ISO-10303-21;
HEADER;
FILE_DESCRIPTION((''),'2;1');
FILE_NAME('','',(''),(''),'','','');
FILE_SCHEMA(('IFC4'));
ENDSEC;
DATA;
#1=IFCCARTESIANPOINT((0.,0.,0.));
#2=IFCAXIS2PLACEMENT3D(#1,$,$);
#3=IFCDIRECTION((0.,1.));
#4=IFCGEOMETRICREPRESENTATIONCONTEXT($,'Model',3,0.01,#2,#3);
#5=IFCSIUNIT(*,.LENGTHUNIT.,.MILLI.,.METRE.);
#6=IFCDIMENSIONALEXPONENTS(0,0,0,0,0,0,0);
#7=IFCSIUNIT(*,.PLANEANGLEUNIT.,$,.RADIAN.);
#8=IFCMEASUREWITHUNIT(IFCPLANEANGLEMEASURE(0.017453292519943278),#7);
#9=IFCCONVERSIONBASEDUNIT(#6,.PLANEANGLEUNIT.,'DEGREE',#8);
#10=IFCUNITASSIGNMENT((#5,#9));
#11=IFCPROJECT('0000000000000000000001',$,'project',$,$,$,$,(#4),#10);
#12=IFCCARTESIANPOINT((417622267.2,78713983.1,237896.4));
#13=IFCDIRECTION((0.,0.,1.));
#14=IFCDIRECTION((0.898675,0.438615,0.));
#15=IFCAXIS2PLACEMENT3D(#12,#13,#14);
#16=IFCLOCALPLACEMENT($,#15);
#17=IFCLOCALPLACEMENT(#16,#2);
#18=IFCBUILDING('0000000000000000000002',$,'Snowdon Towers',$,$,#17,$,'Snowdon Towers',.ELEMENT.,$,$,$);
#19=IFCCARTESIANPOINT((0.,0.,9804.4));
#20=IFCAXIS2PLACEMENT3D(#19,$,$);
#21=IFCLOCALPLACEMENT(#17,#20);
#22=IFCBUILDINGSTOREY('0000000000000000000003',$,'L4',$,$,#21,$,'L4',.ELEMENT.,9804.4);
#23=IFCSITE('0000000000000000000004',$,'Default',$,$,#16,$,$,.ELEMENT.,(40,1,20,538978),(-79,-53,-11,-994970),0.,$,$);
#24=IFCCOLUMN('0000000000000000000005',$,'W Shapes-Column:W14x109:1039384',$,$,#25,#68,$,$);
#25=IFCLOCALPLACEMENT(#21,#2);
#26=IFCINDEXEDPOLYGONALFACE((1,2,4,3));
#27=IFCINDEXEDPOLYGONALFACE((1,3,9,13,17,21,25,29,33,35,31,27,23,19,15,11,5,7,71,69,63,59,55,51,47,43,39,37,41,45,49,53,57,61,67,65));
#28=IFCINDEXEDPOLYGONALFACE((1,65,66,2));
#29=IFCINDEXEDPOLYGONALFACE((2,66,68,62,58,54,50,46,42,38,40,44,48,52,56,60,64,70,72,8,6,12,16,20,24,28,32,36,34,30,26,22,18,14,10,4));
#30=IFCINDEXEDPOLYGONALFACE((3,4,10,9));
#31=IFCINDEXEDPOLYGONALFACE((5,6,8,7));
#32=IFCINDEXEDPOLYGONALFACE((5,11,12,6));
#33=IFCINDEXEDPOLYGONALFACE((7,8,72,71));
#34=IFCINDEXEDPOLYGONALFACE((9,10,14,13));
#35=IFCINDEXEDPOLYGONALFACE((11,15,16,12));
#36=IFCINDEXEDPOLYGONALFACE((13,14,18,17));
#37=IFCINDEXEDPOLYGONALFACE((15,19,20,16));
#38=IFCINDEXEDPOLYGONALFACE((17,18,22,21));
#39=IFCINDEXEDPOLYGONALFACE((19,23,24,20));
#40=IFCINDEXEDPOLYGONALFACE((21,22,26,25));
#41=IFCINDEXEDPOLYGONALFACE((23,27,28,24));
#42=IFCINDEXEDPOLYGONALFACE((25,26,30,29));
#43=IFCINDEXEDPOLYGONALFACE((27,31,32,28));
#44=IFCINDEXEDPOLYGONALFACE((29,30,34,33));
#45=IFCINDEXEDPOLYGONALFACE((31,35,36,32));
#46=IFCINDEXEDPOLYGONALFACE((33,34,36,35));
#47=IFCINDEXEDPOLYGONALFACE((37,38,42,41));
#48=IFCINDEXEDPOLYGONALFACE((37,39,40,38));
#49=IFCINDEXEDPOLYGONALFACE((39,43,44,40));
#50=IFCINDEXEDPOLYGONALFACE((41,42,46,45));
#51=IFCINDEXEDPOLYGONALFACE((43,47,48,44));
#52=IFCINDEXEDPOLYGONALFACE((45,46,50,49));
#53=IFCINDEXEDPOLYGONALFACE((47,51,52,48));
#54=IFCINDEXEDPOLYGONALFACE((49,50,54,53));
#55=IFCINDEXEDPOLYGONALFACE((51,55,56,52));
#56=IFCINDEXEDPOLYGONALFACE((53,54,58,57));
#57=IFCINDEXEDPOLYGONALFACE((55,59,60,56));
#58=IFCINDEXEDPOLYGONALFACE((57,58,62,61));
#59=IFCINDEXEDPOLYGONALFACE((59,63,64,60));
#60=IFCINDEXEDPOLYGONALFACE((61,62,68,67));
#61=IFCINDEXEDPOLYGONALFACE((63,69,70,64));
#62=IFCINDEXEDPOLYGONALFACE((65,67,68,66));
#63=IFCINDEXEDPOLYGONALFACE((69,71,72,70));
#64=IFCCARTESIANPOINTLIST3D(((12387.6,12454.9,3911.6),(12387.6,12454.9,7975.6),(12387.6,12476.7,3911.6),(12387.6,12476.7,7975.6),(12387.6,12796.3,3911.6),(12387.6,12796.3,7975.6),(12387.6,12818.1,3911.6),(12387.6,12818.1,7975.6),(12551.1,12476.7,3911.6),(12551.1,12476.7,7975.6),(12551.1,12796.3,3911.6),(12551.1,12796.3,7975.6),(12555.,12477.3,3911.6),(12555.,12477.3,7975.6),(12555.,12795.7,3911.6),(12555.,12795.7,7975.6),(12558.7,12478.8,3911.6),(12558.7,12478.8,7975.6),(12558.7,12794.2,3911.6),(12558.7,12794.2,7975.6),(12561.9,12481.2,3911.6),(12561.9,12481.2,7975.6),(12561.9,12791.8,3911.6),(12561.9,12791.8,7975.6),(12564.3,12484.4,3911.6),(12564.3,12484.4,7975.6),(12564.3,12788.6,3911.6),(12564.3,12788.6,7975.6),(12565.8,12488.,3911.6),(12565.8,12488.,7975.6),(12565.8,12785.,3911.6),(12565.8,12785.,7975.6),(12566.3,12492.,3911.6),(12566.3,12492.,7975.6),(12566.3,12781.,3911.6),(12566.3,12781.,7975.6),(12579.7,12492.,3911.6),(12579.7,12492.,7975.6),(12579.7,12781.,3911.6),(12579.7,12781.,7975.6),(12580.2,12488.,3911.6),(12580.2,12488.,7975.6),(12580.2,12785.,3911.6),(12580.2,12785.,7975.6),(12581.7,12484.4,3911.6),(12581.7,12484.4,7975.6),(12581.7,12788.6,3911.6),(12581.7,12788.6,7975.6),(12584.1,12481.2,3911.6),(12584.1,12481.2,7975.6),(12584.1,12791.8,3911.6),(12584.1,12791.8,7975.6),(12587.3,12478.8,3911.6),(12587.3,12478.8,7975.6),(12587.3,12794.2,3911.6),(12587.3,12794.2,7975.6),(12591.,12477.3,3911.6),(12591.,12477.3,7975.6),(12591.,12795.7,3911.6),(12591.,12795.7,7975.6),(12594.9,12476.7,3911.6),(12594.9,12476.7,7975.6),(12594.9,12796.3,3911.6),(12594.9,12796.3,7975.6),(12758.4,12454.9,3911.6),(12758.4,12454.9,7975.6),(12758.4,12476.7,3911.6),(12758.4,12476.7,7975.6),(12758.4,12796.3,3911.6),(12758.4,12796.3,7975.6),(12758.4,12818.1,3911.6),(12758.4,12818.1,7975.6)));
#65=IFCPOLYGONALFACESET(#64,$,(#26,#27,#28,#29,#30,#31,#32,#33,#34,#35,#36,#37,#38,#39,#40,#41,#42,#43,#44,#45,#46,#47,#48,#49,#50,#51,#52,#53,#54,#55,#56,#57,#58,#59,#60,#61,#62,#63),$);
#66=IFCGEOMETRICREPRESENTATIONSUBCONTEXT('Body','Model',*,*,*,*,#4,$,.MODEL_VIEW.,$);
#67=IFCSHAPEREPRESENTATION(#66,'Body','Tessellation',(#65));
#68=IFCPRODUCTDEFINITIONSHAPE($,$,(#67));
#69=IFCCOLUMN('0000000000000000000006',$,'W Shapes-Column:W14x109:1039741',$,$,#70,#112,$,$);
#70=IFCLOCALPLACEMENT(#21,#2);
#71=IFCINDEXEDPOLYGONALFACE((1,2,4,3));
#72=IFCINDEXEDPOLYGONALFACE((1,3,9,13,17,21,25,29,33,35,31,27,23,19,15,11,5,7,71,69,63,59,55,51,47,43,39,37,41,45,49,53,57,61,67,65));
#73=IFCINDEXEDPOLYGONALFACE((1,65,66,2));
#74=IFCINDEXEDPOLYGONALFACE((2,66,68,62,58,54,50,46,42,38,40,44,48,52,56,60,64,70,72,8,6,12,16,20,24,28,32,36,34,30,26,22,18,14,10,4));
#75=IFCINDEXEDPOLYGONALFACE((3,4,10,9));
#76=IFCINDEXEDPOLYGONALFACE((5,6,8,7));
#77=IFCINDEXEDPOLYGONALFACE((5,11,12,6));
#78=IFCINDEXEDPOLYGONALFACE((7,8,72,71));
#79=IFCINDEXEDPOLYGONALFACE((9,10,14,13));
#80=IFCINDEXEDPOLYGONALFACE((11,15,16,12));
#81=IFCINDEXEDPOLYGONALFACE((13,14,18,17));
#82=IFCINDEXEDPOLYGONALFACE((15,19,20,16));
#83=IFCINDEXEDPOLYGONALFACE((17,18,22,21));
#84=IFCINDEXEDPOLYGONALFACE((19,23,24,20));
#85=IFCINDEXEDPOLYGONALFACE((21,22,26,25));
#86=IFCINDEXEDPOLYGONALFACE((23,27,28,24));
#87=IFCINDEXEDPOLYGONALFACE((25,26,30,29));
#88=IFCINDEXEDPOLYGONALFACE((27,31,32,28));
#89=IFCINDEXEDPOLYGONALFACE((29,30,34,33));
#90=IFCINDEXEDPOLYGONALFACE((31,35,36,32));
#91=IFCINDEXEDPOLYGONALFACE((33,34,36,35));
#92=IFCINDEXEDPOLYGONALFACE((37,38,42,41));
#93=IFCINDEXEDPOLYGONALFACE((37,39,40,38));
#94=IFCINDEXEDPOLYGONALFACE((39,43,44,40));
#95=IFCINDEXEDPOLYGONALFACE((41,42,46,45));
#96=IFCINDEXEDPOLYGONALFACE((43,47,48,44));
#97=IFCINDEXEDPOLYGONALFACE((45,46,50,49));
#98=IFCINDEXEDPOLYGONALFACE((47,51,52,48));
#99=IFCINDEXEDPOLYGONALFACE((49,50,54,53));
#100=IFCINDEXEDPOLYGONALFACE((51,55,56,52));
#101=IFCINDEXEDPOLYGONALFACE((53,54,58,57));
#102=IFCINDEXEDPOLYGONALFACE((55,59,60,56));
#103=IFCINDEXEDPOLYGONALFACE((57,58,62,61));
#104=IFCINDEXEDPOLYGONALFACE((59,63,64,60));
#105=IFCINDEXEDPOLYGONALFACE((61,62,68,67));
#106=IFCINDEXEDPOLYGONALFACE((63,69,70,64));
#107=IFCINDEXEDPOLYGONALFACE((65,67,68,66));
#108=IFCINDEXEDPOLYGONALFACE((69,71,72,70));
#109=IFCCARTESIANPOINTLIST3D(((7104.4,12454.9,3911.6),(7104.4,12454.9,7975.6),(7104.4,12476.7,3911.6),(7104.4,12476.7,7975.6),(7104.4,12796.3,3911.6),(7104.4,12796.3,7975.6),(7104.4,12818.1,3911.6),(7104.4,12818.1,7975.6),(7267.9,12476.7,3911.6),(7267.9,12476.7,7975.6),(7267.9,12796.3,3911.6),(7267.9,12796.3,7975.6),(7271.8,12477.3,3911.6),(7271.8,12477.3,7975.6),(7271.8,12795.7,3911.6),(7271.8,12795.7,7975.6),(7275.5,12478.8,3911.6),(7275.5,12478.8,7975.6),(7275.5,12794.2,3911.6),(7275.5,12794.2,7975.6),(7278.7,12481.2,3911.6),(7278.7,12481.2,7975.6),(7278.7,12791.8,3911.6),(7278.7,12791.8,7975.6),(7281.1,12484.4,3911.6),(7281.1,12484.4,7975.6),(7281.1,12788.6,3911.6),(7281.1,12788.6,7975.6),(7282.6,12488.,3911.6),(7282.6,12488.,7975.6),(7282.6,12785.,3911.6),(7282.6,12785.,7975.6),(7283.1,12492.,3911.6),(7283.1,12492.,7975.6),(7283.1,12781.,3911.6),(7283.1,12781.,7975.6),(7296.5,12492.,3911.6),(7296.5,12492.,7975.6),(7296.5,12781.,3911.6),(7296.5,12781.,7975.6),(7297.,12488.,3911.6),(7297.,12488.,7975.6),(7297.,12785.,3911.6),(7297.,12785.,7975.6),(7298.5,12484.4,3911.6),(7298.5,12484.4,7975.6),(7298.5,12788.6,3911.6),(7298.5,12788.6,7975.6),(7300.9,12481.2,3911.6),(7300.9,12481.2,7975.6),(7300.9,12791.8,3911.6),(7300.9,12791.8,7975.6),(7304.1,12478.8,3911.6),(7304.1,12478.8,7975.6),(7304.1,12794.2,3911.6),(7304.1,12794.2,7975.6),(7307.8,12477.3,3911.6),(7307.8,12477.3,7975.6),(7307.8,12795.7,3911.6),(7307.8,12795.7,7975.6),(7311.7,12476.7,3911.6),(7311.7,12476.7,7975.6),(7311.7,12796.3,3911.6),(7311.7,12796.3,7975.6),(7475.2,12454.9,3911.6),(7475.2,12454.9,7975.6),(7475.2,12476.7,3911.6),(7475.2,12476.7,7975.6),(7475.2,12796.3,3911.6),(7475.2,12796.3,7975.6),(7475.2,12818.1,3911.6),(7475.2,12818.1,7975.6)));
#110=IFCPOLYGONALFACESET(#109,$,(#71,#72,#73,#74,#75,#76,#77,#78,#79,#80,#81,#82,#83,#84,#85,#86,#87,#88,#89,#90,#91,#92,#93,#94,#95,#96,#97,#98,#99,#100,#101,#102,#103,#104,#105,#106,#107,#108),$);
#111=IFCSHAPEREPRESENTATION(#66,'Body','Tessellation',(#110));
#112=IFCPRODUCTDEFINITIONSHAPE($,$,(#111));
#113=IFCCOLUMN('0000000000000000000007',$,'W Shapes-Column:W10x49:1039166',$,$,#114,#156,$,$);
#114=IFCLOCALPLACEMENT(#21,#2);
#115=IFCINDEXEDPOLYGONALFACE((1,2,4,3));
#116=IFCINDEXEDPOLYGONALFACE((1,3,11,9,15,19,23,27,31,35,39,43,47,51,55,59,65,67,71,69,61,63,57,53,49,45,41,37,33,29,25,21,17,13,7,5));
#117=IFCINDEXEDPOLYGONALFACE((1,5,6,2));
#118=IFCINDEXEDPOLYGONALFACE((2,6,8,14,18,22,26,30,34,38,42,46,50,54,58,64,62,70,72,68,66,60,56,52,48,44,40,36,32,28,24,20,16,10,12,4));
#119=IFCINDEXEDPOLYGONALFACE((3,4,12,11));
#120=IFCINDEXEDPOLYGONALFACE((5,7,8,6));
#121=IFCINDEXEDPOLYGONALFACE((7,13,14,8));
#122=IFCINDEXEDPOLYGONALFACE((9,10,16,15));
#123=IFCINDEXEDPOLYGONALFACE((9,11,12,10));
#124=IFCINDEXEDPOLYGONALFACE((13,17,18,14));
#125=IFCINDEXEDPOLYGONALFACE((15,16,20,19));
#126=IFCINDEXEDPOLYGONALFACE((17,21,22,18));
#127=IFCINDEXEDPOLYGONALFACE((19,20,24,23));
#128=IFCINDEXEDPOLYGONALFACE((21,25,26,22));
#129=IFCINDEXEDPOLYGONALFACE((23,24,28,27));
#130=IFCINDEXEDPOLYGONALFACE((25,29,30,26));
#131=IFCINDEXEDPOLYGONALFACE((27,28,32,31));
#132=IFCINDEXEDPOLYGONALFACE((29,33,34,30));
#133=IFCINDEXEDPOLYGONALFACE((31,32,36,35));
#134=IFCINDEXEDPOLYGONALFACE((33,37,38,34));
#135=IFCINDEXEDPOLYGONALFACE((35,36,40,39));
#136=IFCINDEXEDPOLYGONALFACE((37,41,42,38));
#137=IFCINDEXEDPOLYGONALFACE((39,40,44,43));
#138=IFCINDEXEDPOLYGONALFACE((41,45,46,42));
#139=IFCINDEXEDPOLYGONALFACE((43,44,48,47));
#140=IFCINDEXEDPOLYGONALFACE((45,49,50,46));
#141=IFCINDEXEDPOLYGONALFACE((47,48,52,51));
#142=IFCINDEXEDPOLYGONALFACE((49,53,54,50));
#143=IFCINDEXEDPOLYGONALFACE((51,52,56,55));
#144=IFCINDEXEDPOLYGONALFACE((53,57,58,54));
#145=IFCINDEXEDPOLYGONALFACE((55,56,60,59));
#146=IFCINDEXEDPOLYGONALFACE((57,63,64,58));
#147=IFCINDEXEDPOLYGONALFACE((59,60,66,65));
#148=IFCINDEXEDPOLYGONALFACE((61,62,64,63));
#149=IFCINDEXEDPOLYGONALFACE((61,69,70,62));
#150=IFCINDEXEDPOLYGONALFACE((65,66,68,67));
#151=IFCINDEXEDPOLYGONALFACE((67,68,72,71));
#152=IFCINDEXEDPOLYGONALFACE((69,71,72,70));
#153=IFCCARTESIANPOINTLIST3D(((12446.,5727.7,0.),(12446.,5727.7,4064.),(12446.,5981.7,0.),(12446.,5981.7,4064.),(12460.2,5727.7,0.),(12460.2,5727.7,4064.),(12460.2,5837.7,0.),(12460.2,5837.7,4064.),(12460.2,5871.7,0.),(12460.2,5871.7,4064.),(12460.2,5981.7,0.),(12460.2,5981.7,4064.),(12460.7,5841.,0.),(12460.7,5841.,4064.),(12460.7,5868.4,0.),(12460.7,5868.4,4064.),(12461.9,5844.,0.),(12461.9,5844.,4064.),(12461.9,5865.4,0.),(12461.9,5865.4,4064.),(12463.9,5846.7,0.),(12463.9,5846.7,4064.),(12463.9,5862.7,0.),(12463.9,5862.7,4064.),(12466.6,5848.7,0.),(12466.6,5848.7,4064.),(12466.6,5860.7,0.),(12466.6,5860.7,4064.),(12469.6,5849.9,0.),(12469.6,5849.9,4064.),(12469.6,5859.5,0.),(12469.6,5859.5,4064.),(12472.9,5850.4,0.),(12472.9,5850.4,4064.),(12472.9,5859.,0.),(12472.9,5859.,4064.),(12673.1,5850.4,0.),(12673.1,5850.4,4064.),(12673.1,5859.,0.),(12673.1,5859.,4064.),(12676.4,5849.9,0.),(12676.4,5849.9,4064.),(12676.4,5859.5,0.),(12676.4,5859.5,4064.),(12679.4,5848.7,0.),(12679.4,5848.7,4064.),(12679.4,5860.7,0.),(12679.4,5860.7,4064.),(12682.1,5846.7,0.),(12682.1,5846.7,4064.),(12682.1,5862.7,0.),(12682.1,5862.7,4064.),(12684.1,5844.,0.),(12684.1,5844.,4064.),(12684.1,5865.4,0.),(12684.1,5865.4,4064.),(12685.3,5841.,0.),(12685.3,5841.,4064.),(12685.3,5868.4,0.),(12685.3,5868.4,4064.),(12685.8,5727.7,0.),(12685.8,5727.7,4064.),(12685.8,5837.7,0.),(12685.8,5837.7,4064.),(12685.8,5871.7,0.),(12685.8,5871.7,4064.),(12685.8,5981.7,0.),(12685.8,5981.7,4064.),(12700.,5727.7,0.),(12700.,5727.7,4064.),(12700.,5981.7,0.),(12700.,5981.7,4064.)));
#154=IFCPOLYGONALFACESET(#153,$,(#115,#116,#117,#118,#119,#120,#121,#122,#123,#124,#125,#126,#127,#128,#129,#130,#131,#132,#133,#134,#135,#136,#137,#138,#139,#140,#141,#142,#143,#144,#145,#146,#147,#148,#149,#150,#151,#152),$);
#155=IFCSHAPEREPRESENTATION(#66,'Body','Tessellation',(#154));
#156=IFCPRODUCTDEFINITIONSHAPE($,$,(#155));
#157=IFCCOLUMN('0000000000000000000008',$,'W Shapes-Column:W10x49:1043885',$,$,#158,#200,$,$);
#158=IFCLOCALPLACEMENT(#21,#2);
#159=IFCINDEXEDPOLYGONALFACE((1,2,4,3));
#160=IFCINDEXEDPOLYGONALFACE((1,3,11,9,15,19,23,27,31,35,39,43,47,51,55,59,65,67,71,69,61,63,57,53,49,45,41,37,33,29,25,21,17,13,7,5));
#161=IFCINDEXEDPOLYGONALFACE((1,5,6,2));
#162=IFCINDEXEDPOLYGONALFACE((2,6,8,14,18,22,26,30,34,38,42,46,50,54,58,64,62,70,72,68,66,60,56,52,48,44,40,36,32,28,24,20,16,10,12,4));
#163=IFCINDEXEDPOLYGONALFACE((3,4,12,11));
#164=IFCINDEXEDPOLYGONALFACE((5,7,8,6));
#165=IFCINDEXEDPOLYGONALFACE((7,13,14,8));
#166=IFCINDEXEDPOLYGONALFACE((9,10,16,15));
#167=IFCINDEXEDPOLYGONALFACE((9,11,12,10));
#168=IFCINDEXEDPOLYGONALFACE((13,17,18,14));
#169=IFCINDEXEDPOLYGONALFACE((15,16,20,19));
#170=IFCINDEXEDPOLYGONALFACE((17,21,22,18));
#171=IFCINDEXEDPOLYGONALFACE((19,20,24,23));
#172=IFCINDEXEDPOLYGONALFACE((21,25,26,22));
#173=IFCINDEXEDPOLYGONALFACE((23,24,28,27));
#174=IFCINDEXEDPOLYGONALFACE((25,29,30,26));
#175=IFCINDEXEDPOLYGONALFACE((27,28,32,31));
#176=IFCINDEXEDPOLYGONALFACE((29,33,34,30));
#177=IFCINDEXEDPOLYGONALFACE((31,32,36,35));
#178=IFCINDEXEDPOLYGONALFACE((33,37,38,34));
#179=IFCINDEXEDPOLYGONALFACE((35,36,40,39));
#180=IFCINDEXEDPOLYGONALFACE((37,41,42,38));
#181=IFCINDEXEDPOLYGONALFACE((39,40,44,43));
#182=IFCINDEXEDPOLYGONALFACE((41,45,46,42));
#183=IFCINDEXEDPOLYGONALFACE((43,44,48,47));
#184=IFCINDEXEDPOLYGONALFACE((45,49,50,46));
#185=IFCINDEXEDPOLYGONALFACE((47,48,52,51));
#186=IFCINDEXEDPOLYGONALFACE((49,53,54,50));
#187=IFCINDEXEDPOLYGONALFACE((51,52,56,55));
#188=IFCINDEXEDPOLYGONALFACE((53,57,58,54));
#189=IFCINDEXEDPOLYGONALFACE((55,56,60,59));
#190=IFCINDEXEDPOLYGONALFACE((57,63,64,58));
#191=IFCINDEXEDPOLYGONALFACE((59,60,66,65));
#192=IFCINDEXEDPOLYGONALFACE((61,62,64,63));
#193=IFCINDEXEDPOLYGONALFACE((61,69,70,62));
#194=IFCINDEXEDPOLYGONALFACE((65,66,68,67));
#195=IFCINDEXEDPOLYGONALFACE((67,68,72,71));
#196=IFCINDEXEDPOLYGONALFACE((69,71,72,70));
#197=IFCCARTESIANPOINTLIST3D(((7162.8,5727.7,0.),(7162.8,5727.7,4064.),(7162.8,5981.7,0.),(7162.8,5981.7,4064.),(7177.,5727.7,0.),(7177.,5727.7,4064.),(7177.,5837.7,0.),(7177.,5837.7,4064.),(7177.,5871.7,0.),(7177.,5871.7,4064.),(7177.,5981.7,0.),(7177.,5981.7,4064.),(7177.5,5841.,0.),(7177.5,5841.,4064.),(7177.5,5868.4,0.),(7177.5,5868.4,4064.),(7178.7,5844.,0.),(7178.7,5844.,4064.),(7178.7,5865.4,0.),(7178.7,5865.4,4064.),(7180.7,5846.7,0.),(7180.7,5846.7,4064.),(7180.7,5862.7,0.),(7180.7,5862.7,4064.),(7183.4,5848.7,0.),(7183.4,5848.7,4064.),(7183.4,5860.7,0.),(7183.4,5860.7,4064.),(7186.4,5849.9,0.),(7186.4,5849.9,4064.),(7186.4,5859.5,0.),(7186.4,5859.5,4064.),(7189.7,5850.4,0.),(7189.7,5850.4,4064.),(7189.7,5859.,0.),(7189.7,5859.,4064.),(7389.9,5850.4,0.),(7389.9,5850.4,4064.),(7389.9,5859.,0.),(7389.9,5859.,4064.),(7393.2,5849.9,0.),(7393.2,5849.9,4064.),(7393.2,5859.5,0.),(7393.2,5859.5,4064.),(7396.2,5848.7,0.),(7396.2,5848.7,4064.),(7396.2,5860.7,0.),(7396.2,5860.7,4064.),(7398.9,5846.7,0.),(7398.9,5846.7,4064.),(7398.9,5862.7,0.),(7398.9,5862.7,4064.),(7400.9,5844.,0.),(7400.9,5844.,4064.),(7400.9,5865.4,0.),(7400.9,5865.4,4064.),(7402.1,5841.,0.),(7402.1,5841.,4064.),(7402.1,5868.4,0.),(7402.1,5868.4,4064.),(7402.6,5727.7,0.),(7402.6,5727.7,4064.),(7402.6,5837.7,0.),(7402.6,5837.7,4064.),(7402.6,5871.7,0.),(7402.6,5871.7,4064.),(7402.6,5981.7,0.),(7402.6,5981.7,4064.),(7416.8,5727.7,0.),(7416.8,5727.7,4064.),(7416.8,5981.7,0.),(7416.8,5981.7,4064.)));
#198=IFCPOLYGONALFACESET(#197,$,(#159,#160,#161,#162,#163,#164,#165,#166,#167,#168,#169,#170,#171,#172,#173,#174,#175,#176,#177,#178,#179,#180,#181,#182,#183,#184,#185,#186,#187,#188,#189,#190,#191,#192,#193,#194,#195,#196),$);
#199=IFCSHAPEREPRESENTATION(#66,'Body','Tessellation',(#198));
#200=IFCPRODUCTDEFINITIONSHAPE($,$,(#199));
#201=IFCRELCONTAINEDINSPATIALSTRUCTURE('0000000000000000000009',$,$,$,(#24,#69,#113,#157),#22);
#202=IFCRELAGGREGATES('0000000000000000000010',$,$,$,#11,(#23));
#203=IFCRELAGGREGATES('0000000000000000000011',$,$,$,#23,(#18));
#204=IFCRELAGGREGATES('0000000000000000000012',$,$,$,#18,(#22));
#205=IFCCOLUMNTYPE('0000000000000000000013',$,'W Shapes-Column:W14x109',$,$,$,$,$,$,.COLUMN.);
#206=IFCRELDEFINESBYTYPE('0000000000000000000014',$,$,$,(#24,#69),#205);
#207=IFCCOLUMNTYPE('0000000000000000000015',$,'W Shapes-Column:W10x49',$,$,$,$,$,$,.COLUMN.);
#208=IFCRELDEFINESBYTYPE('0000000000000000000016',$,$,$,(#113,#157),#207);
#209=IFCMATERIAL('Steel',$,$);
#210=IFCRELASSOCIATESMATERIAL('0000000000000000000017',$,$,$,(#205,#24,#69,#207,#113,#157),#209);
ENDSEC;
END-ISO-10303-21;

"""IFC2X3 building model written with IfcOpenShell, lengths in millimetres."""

from ifc_helpers import new_model, entity, si_unit, converted_unit, direction, frame, frame_2d, origin, place, context, subcontext, project, spatial, i_section, extrude, source, transform, mapped, material, type_object, type_shapes, element, save


model = new_model("IFC2X3")

# Units and contexts
model_context = context("Model", 3, precision=0.01, world=origin(), true_north=direction((0.0, 1.0)))
body_context = subcontext(model_context, "Body", "Model", "MODEL_VIEW")
ifc_project = project(units=[si_unit("LENGTHUNIT", "METRE", prefix="MILLI"), converted_unit("PLANEANGLEUNIT", "DEGREE", entity("IfcPlaneAngleMeasure", 0.017453292519943278), si_unit("PLANEANGLEUNIT", "RADIAN"), dimensions=[0, 0, 0, 0, 0, 0, 0])], contexts=[model_context])

# Site, building, storey
site_placement = place(None, frame((417622267.2, 78713983.1, 237896.4), z_axis=(0.0, 0.0, 1.0), x_axis=(0.898675, 0.438615, 0.0)))
site = spatial("IfcSite", under=ifc_project, at=site_placement, Name="Default", CompositionType="ELEMENT", RefLatitude=(40, 1, 20, 538978), RefLongitude=(-79, -53, -11, -994970), RefElevation=0.0)
building_placement = place(site_placement, origin())
building = spatial("IfcBuilding", under=site, at=building_placement, Name="Snowdon Towers", LongName="Snowdon Towers", CompositionType="ELEMENT")
storey_placement = place(building_placement, frame((0.0, 0.0, 9804.4)))
storey = spatial("IfcBuildingStorey", under=building, at=storey_placement, Name="L4", LongName="L4", CompositionType="ELEMENT", Elevation=9804.4)

# Columns
ifc_material_1 = material(Name="Steel")
column_type_1 = type_object("IfcColumnType", Name="W Shapes-Column:W14x109", PredefinedType="COLUMN", material=ifc_material_1)
shared_shape_1 = source(origin(), body_context, "Body", "SweptSolid", [
    extrude(i_section(OverallWidth=370.8, OverallDepth=363.2, WebThickness=13.3, FlangeThickness=21.8, FilletRadius=15.2, at=frame_2d((0.0, 0.0), x_axis=(1.0, 0.0))), frame((0.0, 0.0, 13716.0), z_axis=(0.0, 0.0, 1.0), x_axis=(-1.0, 0.0, 0.0)), (0.0, 0.0, 1.0), 4064.0),
])
type_shapes(column_type_1, [shared_shape_1])
for number, where, z_axis, x_axis, name in (
    (1, (12573.0, 12636.5, -9804.4), (0.0, 0.0, 1.0), (-1.0, 0.0, 0.0), "W Shapes-Column:W14x109:1039384"),
):
    element("IfcColumn", number, at=place(storey_placement, frame(where, z_axis=z_axis, x_axis=x_axis)), inside=storey, type_object=column_type_1, material=ifc_material_1, Name=name, context=body_context, shape_type="MappedRepresentation", body=[
        mapped(shared_shape_1, transform((0.0, 0.0, 0.0), scale=1.0)),
    ])
column_1_placement = place(storey_placement, frame((7289.8, 12636.5, -9804.4)))
element("IfcColumn", 2, at=column_1_placement, inside=storey, type_object=column_type_1, material=ifc_material_1, Name="W Shapes-Column:W14x109:1039741", context=body_context, shape_type="MappedRepresentation", body=[
    mapped(shared_shape_1, transform((0.0, 0.0, 0.0), scale=1.0)),
])
column_type_2 = type_object("IfcColumnType", Name="W Shapes-Column:W10x49", PredefinedType="COLUMN", material=ifc_material_1)
shared_shape_2 = source(origin(), body_context, "Body", "SweptSolid", [
    extrude(i_section(OverallWidth=254.0, OverallDepth=254.0, WebThickness=8.6, FlangeThickness=14.2, FilletRadius=12.7, at=frame_2d((0.0, 0.0), x_axis=(1.0, 0.0))), frame((0.0, 0.0, 9804.4), z_axis=(0.0, 0.0, 1.0), x_axis=(-1.0, 0.0, 0.0)), (0.0, 0.0, 1.0), 4064.0),
])
type_shapes(column_type_2, [shared_shape_2])
for number, where, z_axis, x_axis, name in (
    (3, (12573.0, 5854.7, -9804.4), (0.0, 0.0, 1.0), (0.0, 1.0, 0.0), "W Shapes-Column:W10x49:1039166"),
    (4, (7289.8, 5854.7, -9804.4), (0.0, 0.0, 1.0), (0.0, 1.0, 0.0), "W Shapes-Column:W10x49:1043885"),
):
    element("IfcColumn", number, at=place(storey_placement, frame(where, z_axis=z_axis, x_axis=x_axis)), inside=storey, type_object=column_type_2, material=ifc_material_1, Name=name, context=body_context, shape_type="MappedRepresentation", body=[
        mapped(shared_shape_2, transform((0.0, 0.0, 0.0), scale=1.0)),
    ])

save(model, "model.ifc")
